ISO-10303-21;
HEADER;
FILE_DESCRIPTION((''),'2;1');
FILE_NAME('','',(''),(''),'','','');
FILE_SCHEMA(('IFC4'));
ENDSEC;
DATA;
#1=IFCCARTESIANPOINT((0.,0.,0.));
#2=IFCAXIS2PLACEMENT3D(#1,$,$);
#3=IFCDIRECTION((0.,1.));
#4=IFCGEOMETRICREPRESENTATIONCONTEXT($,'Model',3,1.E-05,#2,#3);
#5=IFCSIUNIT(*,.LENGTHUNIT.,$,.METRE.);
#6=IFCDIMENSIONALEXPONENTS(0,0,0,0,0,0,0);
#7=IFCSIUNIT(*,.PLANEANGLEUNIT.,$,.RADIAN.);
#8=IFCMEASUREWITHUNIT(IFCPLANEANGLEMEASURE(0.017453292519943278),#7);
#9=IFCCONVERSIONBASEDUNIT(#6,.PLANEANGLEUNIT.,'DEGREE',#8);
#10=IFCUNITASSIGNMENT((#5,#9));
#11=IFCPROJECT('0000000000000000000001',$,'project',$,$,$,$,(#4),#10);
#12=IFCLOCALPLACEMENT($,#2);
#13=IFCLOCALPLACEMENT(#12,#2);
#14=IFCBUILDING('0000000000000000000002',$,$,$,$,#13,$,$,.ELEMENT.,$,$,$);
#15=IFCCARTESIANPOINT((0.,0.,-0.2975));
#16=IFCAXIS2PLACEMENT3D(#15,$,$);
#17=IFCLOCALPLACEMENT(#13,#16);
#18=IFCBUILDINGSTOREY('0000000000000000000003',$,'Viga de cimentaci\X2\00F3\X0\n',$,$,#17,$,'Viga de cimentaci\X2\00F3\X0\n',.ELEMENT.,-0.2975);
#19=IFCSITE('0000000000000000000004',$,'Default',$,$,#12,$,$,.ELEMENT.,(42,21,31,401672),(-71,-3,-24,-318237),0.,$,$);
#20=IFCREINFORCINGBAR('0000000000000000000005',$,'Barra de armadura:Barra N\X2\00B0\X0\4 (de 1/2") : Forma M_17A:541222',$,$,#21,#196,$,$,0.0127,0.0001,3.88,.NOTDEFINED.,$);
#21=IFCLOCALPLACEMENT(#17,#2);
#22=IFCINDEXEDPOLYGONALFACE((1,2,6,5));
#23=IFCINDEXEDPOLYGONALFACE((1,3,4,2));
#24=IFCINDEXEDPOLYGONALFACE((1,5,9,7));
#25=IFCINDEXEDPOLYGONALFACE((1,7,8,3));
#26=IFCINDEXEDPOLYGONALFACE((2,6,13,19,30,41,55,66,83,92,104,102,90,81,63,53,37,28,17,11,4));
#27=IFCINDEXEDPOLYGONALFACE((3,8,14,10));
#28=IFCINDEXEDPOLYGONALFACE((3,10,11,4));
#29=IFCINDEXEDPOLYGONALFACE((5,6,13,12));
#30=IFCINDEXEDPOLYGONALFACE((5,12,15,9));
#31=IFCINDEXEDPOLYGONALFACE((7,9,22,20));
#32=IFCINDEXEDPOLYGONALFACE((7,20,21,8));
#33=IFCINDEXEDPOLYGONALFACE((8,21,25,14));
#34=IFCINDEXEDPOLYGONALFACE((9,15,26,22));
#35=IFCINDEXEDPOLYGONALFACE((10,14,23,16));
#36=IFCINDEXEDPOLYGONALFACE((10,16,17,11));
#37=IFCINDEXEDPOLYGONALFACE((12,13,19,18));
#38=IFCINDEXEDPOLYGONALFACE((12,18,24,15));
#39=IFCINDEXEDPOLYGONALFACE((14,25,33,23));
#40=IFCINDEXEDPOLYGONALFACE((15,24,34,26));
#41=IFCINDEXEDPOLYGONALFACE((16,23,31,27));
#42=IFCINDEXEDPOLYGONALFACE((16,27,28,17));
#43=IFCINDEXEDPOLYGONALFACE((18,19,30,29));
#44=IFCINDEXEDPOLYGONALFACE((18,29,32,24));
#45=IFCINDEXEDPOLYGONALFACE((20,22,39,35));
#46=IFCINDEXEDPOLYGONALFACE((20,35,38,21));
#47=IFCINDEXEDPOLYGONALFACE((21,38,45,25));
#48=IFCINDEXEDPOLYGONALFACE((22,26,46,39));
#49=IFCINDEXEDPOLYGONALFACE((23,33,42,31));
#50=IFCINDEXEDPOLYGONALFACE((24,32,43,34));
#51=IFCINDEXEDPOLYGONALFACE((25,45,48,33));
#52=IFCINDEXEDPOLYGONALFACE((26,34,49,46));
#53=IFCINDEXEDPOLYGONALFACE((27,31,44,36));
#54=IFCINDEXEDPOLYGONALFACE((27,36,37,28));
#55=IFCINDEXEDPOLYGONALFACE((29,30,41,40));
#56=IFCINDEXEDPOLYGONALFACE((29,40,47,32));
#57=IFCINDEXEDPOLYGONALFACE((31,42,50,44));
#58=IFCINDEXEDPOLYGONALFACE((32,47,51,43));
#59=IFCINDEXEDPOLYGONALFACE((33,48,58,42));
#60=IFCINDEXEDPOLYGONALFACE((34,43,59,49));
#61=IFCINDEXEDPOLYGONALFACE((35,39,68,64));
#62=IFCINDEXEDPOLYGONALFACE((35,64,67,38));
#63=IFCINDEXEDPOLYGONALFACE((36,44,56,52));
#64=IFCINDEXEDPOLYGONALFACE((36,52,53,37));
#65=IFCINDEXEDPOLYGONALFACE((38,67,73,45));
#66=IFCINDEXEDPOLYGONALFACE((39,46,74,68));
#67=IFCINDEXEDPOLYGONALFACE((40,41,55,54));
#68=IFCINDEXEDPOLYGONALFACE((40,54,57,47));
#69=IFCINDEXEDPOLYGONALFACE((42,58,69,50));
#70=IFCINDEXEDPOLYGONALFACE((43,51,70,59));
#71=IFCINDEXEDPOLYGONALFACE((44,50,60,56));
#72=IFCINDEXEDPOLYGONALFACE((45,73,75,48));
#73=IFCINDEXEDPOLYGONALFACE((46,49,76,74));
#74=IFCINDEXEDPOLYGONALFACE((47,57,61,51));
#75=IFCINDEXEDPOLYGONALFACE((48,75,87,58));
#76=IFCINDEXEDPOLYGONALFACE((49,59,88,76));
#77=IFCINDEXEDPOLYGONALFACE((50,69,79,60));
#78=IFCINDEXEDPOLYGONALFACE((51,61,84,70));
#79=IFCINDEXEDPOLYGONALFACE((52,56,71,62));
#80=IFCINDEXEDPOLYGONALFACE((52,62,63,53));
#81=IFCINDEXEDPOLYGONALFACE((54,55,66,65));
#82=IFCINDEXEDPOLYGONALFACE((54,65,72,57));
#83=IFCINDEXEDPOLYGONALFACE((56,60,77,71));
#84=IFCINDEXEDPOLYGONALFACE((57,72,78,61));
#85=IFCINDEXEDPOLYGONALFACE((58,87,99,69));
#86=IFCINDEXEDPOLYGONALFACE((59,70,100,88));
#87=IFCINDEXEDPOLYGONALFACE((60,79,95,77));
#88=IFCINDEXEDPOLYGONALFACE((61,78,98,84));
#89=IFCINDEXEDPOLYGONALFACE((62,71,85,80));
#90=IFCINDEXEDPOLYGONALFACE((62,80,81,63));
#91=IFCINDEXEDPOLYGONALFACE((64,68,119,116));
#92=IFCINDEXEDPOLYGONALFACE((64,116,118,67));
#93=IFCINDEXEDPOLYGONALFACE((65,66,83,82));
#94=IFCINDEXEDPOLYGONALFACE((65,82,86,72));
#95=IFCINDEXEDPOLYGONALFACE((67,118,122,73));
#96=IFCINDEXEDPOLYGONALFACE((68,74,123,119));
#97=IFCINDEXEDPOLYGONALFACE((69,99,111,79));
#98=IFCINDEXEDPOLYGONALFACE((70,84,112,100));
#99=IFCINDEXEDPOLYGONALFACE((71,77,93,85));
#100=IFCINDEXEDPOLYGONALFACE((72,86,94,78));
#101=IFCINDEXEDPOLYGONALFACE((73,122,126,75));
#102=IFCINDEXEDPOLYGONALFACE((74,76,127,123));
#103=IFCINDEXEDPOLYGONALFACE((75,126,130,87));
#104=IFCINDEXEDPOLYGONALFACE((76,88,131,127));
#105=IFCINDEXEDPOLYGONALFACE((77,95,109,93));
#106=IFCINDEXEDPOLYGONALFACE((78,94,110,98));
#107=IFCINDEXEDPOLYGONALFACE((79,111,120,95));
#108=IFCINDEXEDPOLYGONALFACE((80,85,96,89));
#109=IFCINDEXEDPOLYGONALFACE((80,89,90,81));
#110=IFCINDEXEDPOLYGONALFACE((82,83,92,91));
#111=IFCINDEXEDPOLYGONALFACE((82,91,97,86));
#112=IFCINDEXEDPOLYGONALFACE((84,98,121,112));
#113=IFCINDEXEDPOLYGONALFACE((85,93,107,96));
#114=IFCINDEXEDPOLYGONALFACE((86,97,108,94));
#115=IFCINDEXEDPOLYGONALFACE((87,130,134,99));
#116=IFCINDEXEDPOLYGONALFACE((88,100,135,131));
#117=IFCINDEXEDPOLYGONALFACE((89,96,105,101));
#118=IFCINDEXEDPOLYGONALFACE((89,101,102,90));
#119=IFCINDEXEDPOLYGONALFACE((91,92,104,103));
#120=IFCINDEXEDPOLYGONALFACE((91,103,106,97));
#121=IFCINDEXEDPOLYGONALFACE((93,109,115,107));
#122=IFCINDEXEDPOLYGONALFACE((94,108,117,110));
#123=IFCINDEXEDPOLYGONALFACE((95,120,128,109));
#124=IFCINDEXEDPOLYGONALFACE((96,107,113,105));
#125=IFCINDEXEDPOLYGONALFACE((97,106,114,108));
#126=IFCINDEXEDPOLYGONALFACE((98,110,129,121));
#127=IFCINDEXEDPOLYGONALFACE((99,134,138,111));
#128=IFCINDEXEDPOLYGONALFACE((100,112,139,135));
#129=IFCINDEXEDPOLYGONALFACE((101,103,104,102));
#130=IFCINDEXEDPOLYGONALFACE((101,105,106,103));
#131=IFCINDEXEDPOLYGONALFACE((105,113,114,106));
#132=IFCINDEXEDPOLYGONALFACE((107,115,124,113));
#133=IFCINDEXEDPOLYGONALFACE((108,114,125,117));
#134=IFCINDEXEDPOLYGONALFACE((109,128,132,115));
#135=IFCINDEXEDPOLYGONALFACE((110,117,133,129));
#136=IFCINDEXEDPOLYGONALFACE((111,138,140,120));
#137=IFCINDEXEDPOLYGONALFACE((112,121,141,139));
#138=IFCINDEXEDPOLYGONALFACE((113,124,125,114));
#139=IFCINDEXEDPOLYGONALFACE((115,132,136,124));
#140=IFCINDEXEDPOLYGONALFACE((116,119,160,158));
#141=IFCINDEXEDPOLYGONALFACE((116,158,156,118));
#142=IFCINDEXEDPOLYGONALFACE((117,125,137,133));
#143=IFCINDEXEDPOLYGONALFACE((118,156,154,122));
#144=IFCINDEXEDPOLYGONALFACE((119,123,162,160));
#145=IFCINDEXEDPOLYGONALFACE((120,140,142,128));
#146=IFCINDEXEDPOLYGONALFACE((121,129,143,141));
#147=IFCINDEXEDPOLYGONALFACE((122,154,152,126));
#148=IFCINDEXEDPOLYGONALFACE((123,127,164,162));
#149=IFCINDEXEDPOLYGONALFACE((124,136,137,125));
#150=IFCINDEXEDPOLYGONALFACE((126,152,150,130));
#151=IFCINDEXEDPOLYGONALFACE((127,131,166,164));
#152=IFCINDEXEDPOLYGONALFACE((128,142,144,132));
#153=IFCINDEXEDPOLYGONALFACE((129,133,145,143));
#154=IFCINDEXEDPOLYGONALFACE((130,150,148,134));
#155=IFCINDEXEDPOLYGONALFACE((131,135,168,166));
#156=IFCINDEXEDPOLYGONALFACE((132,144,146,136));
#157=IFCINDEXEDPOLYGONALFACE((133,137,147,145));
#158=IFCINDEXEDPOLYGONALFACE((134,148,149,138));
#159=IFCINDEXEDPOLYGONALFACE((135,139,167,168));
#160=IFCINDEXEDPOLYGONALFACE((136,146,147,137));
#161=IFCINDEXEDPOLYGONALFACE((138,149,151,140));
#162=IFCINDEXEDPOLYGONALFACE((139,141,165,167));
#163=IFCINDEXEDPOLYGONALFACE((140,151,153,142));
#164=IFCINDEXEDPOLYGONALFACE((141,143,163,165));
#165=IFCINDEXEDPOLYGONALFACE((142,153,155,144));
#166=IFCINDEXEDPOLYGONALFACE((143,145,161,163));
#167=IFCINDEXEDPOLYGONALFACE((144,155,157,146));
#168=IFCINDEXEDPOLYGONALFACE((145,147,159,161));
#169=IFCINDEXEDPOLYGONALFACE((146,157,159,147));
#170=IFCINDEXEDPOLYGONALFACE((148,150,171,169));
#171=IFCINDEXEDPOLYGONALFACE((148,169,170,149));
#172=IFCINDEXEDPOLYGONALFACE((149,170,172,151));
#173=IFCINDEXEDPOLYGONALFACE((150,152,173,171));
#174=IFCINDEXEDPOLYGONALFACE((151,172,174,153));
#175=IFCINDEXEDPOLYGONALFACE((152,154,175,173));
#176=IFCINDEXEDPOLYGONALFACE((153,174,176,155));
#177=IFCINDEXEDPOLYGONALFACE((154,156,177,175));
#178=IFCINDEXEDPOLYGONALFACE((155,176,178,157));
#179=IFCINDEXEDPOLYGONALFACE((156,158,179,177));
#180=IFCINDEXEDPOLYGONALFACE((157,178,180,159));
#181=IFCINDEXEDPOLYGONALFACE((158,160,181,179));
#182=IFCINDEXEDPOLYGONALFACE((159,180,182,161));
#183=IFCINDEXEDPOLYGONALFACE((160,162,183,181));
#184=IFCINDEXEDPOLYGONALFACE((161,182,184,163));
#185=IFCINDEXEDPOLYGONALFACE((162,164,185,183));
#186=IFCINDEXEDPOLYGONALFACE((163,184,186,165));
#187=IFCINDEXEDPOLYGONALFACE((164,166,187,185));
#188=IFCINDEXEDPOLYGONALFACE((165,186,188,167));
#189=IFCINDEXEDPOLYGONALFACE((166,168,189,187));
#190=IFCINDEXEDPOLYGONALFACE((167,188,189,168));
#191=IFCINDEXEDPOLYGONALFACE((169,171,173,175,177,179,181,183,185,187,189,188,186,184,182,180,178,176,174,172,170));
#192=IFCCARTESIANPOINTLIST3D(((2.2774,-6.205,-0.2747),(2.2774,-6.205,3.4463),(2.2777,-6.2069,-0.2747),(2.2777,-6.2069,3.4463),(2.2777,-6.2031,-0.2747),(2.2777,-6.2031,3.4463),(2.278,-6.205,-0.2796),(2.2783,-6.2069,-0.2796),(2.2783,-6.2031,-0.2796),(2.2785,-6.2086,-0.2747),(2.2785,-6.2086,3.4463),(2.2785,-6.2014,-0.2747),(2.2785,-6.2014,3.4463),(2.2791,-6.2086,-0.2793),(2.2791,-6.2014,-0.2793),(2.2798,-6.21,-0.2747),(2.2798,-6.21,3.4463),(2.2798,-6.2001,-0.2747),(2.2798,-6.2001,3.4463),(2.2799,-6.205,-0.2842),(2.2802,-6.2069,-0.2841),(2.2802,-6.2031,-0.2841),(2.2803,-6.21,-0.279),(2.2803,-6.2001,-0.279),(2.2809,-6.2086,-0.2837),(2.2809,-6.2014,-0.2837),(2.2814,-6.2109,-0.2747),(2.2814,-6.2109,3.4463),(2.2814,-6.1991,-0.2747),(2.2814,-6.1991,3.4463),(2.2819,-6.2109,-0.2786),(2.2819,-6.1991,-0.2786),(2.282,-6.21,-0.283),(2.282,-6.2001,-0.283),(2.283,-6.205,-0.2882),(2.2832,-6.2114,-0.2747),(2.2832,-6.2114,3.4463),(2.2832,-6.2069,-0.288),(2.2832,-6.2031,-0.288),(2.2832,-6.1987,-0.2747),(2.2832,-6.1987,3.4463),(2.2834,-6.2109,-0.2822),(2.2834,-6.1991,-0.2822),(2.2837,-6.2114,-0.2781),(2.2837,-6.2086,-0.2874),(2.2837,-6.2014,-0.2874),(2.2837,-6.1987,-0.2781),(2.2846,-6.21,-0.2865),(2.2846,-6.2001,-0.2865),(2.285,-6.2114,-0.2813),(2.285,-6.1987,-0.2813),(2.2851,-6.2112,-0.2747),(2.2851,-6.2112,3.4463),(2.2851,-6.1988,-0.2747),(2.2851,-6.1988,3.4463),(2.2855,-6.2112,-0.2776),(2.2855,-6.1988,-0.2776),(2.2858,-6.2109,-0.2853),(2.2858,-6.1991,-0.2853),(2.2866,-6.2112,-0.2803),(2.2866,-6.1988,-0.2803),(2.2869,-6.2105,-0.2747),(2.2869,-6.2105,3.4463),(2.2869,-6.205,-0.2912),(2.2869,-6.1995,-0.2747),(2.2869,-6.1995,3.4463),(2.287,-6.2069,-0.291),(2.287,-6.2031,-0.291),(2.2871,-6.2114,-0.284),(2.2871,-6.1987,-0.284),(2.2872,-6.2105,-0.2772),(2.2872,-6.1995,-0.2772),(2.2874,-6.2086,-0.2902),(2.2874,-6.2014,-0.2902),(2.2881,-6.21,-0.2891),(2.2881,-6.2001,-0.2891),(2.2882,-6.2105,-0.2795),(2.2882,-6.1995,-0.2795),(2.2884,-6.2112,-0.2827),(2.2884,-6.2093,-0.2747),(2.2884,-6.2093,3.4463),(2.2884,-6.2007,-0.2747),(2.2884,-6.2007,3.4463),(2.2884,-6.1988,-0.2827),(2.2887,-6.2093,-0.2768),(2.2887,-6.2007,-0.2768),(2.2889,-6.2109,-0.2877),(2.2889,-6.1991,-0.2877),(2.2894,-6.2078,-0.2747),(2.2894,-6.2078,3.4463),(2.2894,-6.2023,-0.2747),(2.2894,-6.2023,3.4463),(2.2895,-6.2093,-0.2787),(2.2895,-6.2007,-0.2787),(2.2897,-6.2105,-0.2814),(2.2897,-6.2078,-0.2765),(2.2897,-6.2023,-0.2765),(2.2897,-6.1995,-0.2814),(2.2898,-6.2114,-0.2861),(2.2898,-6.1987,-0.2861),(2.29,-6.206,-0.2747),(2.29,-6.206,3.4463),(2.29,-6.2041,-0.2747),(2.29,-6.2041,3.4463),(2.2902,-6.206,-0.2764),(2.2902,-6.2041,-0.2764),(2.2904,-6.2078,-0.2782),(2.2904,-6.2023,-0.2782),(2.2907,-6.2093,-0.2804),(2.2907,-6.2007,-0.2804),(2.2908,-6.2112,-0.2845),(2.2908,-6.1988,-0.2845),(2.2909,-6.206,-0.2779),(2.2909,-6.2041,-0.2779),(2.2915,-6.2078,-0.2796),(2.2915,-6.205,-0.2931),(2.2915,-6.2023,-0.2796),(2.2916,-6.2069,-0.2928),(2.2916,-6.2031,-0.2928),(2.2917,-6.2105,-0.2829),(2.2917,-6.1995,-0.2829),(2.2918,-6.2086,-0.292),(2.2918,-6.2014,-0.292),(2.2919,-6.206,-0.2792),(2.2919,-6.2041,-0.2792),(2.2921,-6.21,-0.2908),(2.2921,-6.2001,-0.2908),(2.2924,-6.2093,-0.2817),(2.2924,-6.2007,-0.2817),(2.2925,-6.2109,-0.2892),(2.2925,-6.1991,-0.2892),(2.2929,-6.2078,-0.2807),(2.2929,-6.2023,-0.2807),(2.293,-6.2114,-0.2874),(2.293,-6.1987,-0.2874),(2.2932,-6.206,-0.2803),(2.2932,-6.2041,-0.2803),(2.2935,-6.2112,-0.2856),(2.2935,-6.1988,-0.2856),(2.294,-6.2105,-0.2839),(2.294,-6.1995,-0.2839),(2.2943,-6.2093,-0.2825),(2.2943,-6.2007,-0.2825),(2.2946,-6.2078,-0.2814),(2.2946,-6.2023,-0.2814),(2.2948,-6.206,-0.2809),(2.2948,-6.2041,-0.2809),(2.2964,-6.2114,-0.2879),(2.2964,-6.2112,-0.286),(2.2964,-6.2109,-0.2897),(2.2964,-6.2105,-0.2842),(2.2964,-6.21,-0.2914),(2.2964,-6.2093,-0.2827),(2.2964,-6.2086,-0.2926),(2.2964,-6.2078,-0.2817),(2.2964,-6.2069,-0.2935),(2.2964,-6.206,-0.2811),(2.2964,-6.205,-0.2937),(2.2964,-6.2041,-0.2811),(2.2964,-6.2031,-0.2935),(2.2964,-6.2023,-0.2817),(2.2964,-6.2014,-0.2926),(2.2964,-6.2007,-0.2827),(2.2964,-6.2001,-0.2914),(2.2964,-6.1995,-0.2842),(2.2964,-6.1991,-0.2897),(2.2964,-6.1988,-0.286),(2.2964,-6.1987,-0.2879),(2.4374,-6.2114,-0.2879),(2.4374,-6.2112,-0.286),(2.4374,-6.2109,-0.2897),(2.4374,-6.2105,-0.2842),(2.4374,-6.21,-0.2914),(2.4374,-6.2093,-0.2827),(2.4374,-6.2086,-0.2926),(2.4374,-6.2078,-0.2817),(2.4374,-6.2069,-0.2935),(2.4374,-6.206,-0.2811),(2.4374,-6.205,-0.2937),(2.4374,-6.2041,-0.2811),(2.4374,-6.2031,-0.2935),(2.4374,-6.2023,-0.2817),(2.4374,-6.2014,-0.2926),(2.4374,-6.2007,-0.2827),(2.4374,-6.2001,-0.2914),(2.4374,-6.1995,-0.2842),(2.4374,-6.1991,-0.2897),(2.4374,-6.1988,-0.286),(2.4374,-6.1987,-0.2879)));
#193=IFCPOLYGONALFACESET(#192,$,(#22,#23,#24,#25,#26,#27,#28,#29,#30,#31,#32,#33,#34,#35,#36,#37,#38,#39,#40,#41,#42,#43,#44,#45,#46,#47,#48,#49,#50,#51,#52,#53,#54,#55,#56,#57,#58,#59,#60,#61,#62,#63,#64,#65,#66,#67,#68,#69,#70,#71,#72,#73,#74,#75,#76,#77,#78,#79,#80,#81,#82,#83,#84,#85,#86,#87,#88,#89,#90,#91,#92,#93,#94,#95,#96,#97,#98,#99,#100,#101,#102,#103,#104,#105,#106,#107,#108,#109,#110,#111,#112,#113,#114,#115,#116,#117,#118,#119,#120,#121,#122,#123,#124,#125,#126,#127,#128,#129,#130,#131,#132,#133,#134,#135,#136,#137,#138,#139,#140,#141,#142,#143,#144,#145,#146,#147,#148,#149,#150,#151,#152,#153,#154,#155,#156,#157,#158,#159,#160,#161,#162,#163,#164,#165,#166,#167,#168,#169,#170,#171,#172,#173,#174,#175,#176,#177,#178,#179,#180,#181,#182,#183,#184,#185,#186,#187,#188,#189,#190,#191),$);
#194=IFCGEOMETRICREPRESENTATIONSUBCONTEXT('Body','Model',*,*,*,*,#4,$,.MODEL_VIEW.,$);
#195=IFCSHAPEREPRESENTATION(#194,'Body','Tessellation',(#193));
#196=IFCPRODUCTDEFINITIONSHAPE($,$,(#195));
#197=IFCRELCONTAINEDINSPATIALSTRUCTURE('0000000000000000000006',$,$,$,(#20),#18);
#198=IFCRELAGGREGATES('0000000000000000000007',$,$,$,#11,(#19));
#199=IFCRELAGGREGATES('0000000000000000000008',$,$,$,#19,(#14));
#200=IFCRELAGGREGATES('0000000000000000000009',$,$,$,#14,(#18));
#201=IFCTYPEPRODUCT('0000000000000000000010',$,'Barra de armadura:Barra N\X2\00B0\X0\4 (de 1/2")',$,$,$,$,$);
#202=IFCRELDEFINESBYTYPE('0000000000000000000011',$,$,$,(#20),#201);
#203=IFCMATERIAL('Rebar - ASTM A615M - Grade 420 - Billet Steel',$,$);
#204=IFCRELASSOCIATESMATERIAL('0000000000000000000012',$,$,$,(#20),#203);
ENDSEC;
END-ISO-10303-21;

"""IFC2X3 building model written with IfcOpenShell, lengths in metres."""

from ifc_helpers import new_model, entity, si_unit, converted_unit, direction, frame, origin, place, context, subcontext, project, spatial, material, type_object, element, save


model = new_model("IFC2X3")

# Units and contexts
model_context = context("Model", 3, precision=1e-05, world=origin(), true_north=direction((0.0, 1.0)))
body_context = subcontext(model_context, "Body", "Model", "MODEL_VIEW")
ifc_project = project(units=[si_unit("LENGTHUNIT", "METRE"), converted_unit("PLANEANGLEUNIT", "DEGREE", entity("IfcPlaneAngleMeasure", 0.017453292519943278), si_unit("PLANEANGLEUNIT", "RADIAN"), dimensions=[0, 0, 0, 0, 0, 0, 0])], contexts=[model_context])

# Site, building, storey
site_placement = place(None, origin())
site = spatial("IfcSite", under=ifc_project, at=site_placement, Name="Default", CompositionType="ELEMENT", RefLatitude=(42, 21, 31, 401672), RefLongitude=(-71, -3, -24, -318237), RefElevation=0.0)
building_placement = place(site_placement, origin())
building = spatial("IfcBuilding", under=site, at=building_placement, CompositionType="ELEMENT")
storey_placement = place(building_placement, frame((0.0, 0.0, -0.2975)))
storey = spatial("IfcBuildingStorey", under=building, at=storey_placement, Name="Viga de cimentación", LongName="Viga de cimentación", CompositionType="ELEMENT", Elevation=-0.2975)

# Reinforcing bar
ifc_material_1 = material(Name="Rebar - ASTM A615M - Grade 420 - Billet Steel")
type_product_1 = type_object("IfcTypeProduct", Name="Barra de armadura:Barra N°4 (de 1/2\")")
reinforcing_bar_1_placement = place(storey_placement, origin())
element("IfcReinforcingBar", 1, at=reinforcing_bar_1_placement, inside=storey, type_object=type_product_1, material=ifc_material_1, Name="Barra de armadura:Barra N°4 (de 1/2\") : Forma M_17A:541222", BarLength=3.88, BarRole="NOTDEFINED", CrossSectionArea=0.0001, NominalDiameter=0.0127, context=body_context, shape_type="AdvancedSweptSolid", body=[
    entity("IfcSweptDiskSolid", entity("IfcCompositeCurve", [entity("IfcCompositeCurveSegment", "CONTINUOUS", True, entity("IfcPolyline", [entity("IfcCartesianPoint", [2.2837, -6.205, 3.4463]), entity("IfcCartesianPoint", [2.2837, -6.205, -0.2747])])), entity("IfcCompositeCurveSegment", "CONTINUOUS", True, entity("IfcTrimmedCurve", entity("IfcCircle", entity("IfcAxis2Placement3D", entity("IfcCartesianPoint", [2.2964, -6.205, -0.2747]), entity("IfcDirection", [0.0, -1.0, 0.0]), entity("IfcDirection", [0.0, 0.0, -1.0])), 0.0127), [entity("IfcParameterValue", 270.0)], [entity("IfcParameterValue", 360.0)], True, "PARAMETER")), entity("IfcCompositeCurveSegment", "CONTINUOUS", True, entity("IfcPolyline", [entity("IfcCartesianPoint", [2.2964, -6.205, -0.2874]), entity("IfcCartesianPoint", [2.4374, -6.205, -0.2874])]))], False), 0.0063, None, 0.0, 92.0),
])

save(model, "model.ifc")
